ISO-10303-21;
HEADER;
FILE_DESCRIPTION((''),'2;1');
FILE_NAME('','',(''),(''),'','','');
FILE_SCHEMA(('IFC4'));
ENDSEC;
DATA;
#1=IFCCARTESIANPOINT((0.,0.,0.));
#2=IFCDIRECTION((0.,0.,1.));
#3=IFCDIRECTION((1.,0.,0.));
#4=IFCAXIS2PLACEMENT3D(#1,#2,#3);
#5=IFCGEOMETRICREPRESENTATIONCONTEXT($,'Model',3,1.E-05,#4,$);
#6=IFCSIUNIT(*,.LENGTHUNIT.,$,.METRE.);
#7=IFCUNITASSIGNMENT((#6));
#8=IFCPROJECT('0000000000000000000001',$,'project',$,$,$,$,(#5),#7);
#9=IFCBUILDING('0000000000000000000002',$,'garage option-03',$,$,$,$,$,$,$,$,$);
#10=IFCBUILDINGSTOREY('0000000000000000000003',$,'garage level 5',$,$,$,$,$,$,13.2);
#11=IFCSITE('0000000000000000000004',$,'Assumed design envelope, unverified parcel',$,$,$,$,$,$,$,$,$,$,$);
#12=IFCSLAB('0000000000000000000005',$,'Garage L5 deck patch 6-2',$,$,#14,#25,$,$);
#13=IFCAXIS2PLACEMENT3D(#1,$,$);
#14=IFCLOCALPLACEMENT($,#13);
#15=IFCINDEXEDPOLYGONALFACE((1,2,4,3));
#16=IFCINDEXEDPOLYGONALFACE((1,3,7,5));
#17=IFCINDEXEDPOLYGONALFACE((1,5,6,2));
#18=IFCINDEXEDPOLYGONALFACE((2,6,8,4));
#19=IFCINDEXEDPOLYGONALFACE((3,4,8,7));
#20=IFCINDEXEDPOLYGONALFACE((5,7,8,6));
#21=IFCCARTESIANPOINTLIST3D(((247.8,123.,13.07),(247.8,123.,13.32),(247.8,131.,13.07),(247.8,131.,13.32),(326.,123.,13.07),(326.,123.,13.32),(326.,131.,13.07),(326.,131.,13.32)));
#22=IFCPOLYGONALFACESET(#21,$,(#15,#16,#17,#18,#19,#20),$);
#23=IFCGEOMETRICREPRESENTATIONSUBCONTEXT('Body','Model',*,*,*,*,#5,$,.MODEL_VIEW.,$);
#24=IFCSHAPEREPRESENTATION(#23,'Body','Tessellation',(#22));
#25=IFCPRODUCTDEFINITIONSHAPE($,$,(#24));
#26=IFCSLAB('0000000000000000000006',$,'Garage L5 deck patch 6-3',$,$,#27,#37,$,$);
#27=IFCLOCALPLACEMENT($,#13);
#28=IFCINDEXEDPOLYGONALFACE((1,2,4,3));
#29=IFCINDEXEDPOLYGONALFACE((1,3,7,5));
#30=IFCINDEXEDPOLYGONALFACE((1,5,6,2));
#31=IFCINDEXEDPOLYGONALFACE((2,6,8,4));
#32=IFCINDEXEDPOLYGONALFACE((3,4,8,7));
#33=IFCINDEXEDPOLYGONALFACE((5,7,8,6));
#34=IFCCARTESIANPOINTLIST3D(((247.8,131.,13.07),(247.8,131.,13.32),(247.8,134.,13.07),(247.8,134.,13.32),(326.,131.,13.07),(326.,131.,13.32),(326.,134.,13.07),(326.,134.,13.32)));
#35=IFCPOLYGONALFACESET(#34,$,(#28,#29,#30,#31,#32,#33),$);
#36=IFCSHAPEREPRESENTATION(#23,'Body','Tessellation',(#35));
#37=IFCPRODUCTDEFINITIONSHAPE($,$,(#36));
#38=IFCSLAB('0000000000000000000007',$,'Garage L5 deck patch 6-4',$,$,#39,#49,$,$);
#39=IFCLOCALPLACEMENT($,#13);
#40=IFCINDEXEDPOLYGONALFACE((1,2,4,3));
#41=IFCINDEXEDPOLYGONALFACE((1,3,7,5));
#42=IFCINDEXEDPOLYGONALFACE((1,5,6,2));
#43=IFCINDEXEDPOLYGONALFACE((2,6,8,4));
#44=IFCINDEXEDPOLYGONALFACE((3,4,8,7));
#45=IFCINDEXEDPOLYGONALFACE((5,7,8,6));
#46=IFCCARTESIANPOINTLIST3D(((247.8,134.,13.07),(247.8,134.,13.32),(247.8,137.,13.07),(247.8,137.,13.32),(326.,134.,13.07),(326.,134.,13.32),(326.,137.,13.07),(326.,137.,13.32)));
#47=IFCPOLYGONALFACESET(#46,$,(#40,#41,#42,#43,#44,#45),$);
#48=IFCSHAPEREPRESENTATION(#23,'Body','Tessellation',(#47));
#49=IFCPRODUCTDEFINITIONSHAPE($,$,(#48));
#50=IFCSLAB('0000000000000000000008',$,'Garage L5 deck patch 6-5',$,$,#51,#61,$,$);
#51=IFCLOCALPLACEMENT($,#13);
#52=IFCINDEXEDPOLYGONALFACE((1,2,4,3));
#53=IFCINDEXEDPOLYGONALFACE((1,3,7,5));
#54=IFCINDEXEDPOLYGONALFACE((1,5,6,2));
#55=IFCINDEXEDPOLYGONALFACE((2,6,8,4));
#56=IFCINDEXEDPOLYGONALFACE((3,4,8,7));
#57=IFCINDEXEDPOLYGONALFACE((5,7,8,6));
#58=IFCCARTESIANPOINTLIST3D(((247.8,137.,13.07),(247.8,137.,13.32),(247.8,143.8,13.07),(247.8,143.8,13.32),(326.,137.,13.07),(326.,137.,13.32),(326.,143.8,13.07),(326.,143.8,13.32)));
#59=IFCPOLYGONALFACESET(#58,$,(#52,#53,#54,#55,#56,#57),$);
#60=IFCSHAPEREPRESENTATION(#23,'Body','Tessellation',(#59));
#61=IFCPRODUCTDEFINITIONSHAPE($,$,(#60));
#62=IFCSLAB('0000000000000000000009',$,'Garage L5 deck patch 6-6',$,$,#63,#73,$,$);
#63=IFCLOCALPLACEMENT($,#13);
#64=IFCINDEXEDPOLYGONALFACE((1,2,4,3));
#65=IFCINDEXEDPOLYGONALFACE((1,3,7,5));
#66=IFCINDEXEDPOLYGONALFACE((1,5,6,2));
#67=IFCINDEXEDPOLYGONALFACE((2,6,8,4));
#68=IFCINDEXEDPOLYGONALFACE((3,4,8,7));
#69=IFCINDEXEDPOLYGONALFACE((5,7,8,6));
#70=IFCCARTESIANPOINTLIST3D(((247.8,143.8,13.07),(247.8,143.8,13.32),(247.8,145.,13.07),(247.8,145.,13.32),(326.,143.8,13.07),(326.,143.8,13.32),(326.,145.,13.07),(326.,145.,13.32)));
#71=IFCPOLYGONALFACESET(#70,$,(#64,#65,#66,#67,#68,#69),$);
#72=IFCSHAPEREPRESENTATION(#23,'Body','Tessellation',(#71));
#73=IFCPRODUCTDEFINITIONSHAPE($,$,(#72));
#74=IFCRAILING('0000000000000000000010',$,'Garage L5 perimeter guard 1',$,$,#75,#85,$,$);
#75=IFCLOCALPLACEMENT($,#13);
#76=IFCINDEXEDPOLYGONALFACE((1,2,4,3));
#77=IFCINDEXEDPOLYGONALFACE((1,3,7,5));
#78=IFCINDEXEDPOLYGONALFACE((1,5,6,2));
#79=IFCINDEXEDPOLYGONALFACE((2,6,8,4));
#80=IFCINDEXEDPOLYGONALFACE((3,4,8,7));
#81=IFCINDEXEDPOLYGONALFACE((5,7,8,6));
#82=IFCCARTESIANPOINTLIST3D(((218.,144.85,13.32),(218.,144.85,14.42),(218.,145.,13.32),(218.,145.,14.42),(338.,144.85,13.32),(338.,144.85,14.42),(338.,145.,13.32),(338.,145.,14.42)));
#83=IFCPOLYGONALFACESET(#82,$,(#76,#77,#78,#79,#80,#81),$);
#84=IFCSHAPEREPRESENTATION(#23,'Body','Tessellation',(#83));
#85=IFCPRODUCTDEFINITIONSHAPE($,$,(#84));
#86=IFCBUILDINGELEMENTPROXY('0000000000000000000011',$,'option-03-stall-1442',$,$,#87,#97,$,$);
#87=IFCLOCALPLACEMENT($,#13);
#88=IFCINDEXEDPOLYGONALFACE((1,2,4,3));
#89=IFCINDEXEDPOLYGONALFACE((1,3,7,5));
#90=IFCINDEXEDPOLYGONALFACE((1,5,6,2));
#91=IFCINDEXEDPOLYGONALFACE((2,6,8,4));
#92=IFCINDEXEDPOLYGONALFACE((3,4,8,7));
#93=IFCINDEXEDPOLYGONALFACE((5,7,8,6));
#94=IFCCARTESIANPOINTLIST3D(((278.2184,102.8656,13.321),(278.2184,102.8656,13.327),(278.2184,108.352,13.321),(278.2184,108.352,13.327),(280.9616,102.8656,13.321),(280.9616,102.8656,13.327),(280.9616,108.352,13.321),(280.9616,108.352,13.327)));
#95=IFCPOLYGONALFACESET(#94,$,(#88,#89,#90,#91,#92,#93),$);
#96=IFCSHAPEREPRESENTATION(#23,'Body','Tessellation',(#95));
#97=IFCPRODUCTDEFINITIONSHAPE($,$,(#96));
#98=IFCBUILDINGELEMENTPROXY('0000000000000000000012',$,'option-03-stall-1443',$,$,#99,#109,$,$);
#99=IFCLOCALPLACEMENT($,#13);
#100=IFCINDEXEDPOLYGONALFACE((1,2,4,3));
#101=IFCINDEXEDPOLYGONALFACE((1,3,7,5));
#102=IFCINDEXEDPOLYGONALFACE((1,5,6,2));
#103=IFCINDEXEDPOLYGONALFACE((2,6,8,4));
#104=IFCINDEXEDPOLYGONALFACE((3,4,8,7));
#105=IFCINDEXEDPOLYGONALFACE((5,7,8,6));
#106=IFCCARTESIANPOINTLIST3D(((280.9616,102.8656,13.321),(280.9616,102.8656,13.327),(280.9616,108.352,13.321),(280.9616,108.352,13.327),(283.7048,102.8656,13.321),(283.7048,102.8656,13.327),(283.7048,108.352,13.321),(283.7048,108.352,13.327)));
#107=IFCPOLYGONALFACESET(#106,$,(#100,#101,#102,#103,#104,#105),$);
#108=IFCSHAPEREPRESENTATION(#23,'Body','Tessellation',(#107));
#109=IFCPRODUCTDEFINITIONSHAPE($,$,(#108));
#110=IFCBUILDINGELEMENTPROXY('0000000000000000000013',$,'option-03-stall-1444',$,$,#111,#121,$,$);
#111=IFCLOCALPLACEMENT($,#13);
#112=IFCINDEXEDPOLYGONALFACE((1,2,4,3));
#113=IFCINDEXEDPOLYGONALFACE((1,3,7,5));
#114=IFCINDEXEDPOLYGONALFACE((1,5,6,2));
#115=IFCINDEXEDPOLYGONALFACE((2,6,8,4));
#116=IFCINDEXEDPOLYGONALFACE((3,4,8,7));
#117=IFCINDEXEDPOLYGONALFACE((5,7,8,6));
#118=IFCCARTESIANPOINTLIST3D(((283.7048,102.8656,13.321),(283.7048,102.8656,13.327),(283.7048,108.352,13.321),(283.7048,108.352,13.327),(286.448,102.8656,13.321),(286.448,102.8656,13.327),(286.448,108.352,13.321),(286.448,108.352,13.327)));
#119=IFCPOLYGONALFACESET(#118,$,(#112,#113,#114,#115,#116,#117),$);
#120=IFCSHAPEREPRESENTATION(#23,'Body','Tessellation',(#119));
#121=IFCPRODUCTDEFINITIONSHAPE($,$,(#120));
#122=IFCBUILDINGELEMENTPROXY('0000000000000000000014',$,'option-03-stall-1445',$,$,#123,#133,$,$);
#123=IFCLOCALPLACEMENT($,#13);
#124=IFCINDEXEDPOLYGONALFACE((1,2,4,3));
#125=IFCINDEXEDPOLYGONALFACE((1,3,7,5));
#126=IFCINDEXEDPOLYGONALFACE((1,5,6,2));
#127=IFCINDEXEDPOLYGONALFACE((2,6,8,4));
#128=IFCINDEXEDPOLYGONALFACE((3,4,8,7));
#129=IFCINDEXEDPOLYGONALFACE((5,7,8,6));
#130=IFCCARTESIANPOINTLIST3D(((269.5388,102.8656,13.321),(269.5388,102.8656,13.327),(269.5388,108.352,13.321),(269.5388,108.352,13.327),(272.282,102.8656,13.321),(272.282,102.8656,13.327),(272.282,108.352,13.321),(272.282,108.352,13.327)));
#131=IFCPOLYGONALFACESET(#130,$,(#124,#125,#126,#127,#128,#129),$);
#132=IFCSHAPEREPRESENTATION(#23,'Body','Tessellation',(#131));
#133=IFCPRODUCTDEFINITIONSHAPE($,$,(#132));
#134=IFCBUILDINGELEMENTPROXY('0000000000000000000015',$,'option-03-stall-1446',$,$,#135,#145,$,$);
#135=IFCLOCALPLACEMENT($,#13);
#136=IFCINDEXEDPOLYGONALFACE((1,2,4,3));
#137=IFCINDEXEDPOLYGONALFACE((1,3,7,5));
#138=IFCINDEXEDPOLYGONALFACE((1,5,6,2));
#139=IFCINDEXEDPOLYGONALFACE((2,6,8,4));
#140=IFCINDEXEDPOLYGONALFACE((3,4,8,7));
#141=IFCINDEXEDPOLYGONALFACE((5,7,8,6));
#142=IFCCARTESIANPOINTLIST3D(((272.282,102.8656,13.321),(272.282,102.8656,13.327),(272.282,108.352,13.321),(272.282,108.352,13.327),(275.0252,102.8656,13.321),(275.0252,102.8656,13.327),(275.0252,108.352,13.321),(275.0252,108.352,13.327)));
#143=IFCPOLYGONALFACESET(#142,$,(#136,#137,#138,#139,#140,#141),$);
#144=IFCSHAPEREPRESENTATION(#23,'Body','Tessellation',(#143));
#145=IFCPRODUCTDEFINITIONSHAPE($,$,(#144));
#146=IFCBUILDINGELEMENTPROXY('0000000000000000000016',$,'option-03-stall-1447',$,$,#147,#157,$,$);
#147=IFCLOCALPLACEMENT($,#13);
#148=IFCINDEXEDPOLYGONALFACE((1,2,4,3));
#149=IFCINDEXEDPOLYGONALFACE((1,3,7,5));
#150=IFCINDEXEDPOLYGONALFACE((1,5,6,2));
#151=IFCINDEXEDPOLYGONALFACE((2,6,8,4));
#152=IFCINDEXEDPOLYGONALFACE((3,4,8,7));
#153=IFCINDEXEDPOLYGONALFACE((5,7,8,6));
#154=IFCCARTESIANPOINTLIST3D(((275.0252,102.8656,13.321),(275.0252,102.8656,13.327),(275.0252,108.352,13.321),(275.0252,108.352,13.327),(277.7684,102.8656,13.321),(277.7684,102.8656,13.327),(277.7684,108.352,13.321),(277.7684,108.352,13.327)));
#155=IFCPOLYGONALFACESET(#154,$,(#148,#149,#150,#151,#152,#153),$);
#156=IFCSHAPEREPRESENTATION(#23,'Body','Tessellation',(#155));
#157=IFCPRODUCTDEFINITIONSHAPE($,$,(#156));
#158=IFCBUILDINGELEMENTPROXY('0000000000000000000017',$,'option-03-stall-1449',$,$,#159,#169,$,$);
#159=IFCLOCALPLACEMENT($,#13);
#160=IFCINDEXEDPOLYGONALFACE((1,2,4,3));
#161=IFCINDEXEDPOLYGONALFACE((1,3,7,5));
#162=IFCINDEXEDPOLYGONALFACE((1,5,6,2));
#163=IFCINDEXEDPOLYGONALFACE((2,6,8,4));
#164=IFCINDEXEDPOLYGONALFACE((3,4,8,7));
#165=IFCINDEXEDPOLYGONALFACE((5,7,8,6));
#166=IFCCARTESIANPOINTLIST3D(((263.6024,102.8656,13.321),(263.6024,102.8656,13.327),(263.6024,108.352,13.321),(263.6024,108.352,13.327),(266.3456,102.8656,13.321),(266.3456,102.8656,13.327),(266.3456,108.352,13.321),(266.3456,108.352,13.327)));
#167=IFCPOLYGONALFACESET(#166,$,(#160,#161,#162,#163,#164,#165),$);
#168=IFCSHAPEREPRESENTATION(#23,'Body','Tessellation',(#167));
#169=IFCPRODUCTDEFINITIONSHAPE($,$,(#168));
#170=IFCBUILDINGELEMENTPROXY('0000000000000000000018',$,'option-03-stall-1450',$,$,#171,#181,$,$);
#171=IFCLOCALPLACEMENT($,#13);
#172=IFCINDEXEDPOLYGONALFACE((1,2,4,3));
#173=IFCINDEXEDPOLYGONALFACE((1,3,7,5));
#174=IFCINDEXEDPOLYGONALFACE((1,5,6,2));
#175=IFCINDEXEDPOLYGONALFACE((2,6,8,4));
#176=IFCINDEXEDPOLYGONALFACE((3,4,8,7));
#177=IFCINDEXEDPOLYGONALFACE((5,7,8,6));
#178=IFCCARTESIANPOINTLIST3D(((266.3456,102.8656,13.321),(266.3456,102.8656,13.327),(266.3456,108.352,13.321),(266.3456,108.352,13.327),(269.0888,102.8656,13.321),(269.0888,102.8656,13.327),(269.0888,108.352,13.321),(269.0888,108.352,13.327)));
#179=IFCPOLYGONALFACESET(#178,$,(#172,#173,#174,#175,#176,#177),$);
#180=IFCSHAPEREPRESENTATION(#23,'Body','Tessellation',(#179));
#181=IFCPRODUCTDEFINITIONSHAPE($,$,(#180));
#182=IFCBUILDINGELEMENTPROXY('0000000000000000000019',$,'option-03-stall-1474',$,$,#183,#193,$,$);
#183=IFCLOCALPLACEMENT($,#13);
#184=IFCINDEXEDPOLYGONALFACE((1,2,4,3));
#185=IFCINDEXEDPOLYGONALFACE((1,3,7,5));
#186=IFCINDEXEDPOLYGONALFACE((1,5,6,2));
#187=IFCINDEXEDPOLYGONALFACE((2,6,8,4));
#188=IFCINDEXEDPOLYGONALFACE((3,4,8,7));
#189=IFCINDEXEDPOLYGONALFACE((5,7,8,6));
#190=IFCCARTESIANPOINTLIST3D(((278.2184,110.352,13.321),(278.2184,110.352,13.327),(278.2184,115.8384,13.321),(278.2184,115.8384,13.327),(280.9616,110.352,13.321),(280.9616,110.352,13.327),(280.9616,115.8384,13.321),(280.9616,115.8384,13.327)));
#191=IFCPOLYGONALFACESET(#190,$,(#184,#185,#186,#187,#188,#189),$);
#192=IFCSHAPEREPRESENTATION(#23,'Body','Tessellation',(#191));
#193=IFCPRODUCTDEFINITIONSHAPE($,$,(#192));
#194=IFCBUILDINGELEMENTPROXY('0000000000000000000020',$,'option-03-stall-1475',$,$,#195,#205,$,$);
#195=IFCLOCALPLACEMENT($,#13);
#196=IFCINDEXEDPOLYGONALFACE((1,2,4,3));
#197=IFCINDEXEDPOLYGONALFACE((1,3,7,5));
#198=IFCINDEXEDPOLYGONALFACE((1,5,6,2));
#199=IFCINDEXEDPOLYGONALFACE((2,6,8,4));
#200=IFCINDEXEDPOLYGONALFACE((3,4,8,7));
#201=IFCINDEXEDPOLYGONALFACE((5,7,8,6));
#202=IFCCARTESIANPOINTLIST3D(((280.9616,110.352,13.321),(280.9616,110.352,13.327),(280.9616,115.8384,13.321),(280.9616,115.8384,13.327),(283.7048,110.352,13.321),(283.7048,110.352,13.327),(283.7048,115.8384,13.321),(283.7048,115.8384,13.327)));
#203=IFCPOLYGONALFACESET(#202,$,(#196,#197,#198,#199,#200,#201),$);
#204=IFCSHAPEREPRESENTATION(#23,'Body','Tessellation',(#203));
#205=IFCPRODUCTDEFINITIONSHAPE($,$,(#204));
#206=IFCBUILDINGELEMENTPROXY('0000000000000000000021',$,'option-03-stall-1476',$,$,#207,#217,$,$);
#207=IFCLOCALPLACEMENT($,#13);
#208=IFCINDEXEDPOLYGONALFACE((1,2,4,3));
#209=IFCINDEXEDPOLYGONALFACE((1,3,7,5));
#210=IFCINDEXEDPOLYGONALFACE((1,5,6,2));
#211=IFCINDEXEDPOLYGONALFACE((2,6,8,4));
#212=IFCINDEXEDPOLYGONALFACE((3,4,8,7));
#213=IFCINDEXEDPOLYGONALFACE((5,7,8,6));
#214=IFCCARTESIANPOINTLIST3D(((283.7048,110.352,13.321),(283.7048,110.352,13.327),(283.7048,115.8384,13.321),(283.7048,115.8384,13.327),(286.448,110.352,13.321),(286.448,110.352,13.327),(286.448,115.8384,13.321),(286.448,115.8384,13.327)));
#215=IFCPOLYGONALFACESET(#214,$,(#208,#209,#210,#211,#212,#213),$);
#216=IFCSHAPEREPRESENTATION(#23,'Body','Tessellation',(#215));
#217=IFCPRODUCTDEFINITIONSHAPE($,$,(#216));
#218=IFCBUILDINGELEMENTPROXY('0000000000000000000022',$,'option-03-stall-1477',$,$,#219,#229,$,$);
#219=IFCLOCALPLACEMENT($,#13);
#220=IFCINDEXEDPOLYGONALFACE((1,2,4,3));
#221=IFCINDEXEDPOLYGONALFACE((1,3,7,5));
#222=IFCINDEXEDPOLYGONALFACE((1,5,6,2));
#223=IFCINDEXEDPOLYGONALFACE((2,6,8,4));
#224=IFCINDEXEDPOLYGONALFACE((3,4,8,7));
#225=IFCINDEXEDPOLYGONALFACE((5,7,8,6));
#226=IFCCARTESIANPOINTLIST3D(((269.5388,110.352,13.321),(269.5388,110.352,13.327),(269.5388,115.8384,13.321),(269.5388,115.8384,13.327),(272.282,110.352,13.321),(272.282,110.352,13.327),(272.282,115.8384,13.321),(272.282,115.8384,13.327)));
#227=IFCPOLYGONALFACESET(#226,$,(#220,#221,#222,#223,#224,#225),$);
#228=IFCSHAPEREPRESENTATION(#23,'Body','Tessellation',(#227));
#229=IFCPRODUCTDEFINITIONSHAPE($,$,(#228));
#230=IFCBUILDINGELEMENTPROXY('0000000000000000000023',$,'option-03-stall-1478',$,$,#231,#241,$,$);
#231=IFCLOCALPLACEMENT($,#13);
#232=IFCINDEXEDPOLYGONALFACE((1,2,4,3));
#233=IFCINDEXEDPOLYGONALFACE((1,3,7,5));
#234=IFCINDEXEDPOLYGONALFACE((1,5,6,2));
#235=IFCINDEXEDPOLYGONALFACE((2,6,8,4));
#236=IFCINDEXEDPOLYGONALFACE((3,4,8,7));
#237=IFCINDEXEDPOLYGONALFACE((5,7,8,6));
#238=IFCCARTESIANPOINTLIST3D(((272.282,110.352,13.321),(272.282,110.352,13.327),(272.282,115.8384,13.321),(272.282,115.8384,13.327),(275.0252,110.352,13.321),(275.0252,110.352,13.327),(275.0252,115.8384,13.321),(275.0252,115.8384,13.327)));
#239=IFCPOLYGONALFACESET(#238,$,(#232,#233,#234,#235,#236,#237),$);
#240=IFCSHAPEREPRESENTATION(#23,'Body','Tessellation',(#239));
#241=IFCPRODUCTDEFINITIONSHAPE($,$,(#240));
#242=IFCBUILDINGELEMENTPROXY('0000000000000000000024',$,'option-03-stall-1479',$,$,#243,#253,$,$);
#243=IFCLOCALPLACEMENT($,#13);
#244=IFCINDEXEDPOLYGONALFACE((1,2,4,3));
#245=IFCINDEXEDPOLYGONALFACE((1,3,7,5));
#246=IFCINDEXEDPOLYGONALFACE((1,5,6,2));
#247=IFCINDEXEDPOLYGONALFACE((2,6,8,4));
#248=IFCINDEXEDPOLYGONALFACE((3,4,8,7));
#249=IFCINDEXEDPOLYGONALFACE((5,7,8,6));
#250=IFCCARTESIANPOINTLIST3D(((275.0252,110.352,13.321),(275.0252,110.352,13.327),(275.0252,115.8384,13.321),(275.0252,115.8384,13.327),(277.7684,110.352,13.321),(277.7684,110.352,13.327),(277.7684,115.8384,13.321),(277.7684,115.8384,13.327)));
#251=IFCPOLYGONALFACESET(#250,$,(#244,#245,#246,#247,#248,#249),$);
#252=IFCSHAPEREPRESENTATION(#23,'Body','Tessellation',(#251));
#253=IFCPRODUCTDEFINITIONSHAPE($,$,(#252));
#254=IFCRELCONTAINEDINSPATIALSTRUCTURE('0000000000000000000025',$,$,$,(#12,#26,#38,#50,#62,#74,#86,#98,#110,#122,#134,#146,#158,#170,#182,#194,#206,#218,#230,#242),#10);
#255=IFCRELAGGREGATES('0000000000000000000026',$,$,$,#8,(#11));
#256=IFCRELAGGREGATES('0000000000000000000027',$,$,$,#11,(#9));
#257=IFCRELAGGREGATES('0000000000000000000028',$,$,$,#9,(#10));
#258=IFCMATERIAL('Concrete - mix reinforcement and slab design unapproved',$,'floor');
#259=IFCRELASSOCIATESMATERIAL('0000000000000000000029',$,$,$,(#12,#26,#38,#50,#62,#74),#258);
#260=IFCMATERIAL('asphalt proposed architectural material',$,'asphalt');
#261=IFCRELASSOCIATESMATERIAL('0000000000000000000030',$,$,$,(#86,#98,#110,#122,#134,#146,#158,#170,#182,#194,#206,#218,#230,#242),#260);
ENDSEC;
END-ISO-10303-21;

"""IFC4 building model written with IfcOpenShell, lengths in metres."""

from ifc_helpers import new_model, si_unit, frame, origin_with_axes, place, context, subcontext, project, spatial, rectangle, extrude, material, element, save


model = new_model("IFC4")

# Units and contexts
model_context = context("Model", 3, precision=1e-05, world=origin_with_axes())
body_context = subcontext(model_context, "Body", "Model", "MODEL_VIEW")
ifc_project = project(units=[si_unit("LENGTHUNIT", "METRE")], contexts=[model_context])

# Site, building, storey
site = spatial("IfcSite", under=ifc_project, Name="Assumed design envelope, unverified parcel")
building = spatial("IfcBuilding", under=site, Name="garage option-03")
storey = spatial("IfcBuildingStorey", under=building, Name="garage level 5", Elevation=13.2)

# Slabs
ifc_material_1 = material(Name="Concrete - mix reinforcement and slab design unapproved", Category="floor")
slab_1_placement = place(None, frame((286.9, 127.0, 13.07), z_axis=(0.0, 0.0, 1.0), x_axis=(1.0, 0.0, 0.0)))
element("IfcSlab", 1, at=slab_1_placement, inside=storey, material=ifc_material_1, Name="Garage L5 deck patch 6-2", context=body_context, shape_type="SweptSolid", body=[
    extrude(rectangle(XDim=78.2, YDim=8.0), origin_with_axes(), (0.0, 0.0, 1.0), 0.25),
])
for number, where, z_axis, x_axis, name in (
    (2, (286.9, 132.5, 13.07), (0.0, 0.0, 1.0), (1.0, 0.0, 0.0), "Garage L5 deck patch 6-3"),
    (3, (286.9, 135.5, 13.07), (0.0, 0.0, 1.0), (1.0, 0.0, 0.0), "Garage L5 deck patch 6-4"),
):
    element("IfcSlab", number, at=place(None, frame(where, z_axis=z_axis, x_axis=x_axis)), inside=storey, material=ifc_material_1, Name=name, context=body_context, shape_type="SweptSolid", body=[
        extrude(rectangle(XDim=78.2, YDim=3.0), origin_with_axes(), (0.0, 0.0, 1.0), 0.25),
    ])
slab_2_placement = place(None, frame((286.9, 140.4, 13.07), z_axis=(0.0, 0.0, 1.0), x_axis=(1.0, 0.0, 0.0)))
element("IfcSlab", 4, at=slab_2_placement, inside=storey, material=ifc_material_1, Name="Garage L5 deck patch 6-5", context=body_context, shape_type="SweptSolid", body=[
    extrude(rectangle(XDim=78.2, YDim=6.8), origin_with_axes(), (0.0, 0.0, 1.0), 0.25),
])
slab_3_placement = place(None, frame((286.9, 144.4, 13.07), z_axis=(0.0, 0.0, 1.0), x_axis=(1.0, 0.0, 0.0)))
element("IfcSlab", 5, at=slab_3_placement, inside=storey, material=ifc_material_1, Name="Garage L5 deck patch 6-6", context=body_context, shape_type="SweptSolid", body=[
    extrude(rectangle(XDim=78.2, YDim=1.2), origin_with_axes(), (0.0, 0.0, 1.0), 0.25),
])

# Railing
railing_placement = place(None, frame((278.0, 144.925, 13.32), z_axis=(0.0, 0.0, 1.0), x_axis=(1.0, 0.0, 0.0)))
element("IfcRailing", 6, at=railing_placement, inside=storey, material=ifc_material_1, Name="Garage L5 perimeter guard 1", context=body_context, shape_type="SweptSolid", body=[
    extrude(rectangle(XDim=120.0, YDim=0.15), origin_with_axes(), (0.0, 0.0, 1.0), 1.1),
])

# Building element proxies
ifc_material_2 = material(Name="asphalt proposed architectural material", Category="asphalt")
for number, where, z_axis, x_axis, name in (
    (7, (279.59, 105.6088, 13.321), (0.0, 0.0, 1.0), (1.0, 0.0, 0.0), "option-03-stall-1442"),
    (8, (282.3332, 105.6088, 13.321), (0.0, 0.0, 1.0), (1.0, 0.0, 0.0), "option-03-stall-1443"),
    (9, (285.0764, 105.6088, 13.321), (0.0, 0.0, 1.0), (1.0, 0.0, 0.0), "option-03-stall-1444"),
    (10, (270.9104, 105.6088, 13.321), (0.0, 0.0, 1.0), (1.0, 0.0, 0.0), "option-03-stall-1445"),
    (11, (273.6536, 105.6088, 13.321), (0.0, 0.0, 1.0), (1.0, 0.0, 0.0), "option-03-stall-1446"),
    (12, (276.3968, 105.6088, 13.321), (0.0, 0.0, 1.0), (1.0, 0.0, 0.0), "option-03-stall-1447"),
    (13, (264.974, 105.6088, 13.321), (0.0, 0.0, 1.0), (1.0, 0.0, 0.0), "option-03-stall-1449"),
    (14, (267.7172, 105.6088, 13.321), (0.0, 0.0, 1.0), (1.0, 0.0, 0.0), "option-03-stall-1450"),
    (15, (279.59, 113.0952, 13.321), (0.0, 0.0, 1.0), (1.0, 0.0, 0.0), "option-03-stall-1474"),
    (16, (282.3332, 113.0952, 13.321), (0.0, 0.0, 1.0), (1.0, 0.0, 0.0), "option-03-stall-1475"),
    (17, (285.0764, 113.0952, 13.321), (0.0, 0.0, 1.0), (1.0, 0.0, 0.0), "option-03-stall-1476"),
    (18, (270.9104, 113.0952, 13.321), (0.0, 0.0, 1.0), (1.0, 0.0, 0.0), "option-03-stall-1477"),
    (19, (273.6536, 113.0952, 13.321), (0.0, 0.0, 1.0), (1.0, 0.0, 0.0), "option-03-stall-1478"),
    (20, (276.3968, 113.0952, 13.321), (0.0, 0.0, 1.0), (1.0, 0.0, 0.0), "option-03-stall-1479"),
):
    element("IfcBuildingElementProxy", number, at=place(None, frame(where, z_axis=z_axis, x_axis=x_axis)), inside=storey, material=ifc_material_2, Name=name, context=body_context, shape_type="SweptSolid", body=[
        extrude(rectangle(XDim=2.7432, YDim=5.4864), origin_with_axes(), (0.0, 0.0, 1.0), 0.006),
    ])

save(model, "model.ifc")
